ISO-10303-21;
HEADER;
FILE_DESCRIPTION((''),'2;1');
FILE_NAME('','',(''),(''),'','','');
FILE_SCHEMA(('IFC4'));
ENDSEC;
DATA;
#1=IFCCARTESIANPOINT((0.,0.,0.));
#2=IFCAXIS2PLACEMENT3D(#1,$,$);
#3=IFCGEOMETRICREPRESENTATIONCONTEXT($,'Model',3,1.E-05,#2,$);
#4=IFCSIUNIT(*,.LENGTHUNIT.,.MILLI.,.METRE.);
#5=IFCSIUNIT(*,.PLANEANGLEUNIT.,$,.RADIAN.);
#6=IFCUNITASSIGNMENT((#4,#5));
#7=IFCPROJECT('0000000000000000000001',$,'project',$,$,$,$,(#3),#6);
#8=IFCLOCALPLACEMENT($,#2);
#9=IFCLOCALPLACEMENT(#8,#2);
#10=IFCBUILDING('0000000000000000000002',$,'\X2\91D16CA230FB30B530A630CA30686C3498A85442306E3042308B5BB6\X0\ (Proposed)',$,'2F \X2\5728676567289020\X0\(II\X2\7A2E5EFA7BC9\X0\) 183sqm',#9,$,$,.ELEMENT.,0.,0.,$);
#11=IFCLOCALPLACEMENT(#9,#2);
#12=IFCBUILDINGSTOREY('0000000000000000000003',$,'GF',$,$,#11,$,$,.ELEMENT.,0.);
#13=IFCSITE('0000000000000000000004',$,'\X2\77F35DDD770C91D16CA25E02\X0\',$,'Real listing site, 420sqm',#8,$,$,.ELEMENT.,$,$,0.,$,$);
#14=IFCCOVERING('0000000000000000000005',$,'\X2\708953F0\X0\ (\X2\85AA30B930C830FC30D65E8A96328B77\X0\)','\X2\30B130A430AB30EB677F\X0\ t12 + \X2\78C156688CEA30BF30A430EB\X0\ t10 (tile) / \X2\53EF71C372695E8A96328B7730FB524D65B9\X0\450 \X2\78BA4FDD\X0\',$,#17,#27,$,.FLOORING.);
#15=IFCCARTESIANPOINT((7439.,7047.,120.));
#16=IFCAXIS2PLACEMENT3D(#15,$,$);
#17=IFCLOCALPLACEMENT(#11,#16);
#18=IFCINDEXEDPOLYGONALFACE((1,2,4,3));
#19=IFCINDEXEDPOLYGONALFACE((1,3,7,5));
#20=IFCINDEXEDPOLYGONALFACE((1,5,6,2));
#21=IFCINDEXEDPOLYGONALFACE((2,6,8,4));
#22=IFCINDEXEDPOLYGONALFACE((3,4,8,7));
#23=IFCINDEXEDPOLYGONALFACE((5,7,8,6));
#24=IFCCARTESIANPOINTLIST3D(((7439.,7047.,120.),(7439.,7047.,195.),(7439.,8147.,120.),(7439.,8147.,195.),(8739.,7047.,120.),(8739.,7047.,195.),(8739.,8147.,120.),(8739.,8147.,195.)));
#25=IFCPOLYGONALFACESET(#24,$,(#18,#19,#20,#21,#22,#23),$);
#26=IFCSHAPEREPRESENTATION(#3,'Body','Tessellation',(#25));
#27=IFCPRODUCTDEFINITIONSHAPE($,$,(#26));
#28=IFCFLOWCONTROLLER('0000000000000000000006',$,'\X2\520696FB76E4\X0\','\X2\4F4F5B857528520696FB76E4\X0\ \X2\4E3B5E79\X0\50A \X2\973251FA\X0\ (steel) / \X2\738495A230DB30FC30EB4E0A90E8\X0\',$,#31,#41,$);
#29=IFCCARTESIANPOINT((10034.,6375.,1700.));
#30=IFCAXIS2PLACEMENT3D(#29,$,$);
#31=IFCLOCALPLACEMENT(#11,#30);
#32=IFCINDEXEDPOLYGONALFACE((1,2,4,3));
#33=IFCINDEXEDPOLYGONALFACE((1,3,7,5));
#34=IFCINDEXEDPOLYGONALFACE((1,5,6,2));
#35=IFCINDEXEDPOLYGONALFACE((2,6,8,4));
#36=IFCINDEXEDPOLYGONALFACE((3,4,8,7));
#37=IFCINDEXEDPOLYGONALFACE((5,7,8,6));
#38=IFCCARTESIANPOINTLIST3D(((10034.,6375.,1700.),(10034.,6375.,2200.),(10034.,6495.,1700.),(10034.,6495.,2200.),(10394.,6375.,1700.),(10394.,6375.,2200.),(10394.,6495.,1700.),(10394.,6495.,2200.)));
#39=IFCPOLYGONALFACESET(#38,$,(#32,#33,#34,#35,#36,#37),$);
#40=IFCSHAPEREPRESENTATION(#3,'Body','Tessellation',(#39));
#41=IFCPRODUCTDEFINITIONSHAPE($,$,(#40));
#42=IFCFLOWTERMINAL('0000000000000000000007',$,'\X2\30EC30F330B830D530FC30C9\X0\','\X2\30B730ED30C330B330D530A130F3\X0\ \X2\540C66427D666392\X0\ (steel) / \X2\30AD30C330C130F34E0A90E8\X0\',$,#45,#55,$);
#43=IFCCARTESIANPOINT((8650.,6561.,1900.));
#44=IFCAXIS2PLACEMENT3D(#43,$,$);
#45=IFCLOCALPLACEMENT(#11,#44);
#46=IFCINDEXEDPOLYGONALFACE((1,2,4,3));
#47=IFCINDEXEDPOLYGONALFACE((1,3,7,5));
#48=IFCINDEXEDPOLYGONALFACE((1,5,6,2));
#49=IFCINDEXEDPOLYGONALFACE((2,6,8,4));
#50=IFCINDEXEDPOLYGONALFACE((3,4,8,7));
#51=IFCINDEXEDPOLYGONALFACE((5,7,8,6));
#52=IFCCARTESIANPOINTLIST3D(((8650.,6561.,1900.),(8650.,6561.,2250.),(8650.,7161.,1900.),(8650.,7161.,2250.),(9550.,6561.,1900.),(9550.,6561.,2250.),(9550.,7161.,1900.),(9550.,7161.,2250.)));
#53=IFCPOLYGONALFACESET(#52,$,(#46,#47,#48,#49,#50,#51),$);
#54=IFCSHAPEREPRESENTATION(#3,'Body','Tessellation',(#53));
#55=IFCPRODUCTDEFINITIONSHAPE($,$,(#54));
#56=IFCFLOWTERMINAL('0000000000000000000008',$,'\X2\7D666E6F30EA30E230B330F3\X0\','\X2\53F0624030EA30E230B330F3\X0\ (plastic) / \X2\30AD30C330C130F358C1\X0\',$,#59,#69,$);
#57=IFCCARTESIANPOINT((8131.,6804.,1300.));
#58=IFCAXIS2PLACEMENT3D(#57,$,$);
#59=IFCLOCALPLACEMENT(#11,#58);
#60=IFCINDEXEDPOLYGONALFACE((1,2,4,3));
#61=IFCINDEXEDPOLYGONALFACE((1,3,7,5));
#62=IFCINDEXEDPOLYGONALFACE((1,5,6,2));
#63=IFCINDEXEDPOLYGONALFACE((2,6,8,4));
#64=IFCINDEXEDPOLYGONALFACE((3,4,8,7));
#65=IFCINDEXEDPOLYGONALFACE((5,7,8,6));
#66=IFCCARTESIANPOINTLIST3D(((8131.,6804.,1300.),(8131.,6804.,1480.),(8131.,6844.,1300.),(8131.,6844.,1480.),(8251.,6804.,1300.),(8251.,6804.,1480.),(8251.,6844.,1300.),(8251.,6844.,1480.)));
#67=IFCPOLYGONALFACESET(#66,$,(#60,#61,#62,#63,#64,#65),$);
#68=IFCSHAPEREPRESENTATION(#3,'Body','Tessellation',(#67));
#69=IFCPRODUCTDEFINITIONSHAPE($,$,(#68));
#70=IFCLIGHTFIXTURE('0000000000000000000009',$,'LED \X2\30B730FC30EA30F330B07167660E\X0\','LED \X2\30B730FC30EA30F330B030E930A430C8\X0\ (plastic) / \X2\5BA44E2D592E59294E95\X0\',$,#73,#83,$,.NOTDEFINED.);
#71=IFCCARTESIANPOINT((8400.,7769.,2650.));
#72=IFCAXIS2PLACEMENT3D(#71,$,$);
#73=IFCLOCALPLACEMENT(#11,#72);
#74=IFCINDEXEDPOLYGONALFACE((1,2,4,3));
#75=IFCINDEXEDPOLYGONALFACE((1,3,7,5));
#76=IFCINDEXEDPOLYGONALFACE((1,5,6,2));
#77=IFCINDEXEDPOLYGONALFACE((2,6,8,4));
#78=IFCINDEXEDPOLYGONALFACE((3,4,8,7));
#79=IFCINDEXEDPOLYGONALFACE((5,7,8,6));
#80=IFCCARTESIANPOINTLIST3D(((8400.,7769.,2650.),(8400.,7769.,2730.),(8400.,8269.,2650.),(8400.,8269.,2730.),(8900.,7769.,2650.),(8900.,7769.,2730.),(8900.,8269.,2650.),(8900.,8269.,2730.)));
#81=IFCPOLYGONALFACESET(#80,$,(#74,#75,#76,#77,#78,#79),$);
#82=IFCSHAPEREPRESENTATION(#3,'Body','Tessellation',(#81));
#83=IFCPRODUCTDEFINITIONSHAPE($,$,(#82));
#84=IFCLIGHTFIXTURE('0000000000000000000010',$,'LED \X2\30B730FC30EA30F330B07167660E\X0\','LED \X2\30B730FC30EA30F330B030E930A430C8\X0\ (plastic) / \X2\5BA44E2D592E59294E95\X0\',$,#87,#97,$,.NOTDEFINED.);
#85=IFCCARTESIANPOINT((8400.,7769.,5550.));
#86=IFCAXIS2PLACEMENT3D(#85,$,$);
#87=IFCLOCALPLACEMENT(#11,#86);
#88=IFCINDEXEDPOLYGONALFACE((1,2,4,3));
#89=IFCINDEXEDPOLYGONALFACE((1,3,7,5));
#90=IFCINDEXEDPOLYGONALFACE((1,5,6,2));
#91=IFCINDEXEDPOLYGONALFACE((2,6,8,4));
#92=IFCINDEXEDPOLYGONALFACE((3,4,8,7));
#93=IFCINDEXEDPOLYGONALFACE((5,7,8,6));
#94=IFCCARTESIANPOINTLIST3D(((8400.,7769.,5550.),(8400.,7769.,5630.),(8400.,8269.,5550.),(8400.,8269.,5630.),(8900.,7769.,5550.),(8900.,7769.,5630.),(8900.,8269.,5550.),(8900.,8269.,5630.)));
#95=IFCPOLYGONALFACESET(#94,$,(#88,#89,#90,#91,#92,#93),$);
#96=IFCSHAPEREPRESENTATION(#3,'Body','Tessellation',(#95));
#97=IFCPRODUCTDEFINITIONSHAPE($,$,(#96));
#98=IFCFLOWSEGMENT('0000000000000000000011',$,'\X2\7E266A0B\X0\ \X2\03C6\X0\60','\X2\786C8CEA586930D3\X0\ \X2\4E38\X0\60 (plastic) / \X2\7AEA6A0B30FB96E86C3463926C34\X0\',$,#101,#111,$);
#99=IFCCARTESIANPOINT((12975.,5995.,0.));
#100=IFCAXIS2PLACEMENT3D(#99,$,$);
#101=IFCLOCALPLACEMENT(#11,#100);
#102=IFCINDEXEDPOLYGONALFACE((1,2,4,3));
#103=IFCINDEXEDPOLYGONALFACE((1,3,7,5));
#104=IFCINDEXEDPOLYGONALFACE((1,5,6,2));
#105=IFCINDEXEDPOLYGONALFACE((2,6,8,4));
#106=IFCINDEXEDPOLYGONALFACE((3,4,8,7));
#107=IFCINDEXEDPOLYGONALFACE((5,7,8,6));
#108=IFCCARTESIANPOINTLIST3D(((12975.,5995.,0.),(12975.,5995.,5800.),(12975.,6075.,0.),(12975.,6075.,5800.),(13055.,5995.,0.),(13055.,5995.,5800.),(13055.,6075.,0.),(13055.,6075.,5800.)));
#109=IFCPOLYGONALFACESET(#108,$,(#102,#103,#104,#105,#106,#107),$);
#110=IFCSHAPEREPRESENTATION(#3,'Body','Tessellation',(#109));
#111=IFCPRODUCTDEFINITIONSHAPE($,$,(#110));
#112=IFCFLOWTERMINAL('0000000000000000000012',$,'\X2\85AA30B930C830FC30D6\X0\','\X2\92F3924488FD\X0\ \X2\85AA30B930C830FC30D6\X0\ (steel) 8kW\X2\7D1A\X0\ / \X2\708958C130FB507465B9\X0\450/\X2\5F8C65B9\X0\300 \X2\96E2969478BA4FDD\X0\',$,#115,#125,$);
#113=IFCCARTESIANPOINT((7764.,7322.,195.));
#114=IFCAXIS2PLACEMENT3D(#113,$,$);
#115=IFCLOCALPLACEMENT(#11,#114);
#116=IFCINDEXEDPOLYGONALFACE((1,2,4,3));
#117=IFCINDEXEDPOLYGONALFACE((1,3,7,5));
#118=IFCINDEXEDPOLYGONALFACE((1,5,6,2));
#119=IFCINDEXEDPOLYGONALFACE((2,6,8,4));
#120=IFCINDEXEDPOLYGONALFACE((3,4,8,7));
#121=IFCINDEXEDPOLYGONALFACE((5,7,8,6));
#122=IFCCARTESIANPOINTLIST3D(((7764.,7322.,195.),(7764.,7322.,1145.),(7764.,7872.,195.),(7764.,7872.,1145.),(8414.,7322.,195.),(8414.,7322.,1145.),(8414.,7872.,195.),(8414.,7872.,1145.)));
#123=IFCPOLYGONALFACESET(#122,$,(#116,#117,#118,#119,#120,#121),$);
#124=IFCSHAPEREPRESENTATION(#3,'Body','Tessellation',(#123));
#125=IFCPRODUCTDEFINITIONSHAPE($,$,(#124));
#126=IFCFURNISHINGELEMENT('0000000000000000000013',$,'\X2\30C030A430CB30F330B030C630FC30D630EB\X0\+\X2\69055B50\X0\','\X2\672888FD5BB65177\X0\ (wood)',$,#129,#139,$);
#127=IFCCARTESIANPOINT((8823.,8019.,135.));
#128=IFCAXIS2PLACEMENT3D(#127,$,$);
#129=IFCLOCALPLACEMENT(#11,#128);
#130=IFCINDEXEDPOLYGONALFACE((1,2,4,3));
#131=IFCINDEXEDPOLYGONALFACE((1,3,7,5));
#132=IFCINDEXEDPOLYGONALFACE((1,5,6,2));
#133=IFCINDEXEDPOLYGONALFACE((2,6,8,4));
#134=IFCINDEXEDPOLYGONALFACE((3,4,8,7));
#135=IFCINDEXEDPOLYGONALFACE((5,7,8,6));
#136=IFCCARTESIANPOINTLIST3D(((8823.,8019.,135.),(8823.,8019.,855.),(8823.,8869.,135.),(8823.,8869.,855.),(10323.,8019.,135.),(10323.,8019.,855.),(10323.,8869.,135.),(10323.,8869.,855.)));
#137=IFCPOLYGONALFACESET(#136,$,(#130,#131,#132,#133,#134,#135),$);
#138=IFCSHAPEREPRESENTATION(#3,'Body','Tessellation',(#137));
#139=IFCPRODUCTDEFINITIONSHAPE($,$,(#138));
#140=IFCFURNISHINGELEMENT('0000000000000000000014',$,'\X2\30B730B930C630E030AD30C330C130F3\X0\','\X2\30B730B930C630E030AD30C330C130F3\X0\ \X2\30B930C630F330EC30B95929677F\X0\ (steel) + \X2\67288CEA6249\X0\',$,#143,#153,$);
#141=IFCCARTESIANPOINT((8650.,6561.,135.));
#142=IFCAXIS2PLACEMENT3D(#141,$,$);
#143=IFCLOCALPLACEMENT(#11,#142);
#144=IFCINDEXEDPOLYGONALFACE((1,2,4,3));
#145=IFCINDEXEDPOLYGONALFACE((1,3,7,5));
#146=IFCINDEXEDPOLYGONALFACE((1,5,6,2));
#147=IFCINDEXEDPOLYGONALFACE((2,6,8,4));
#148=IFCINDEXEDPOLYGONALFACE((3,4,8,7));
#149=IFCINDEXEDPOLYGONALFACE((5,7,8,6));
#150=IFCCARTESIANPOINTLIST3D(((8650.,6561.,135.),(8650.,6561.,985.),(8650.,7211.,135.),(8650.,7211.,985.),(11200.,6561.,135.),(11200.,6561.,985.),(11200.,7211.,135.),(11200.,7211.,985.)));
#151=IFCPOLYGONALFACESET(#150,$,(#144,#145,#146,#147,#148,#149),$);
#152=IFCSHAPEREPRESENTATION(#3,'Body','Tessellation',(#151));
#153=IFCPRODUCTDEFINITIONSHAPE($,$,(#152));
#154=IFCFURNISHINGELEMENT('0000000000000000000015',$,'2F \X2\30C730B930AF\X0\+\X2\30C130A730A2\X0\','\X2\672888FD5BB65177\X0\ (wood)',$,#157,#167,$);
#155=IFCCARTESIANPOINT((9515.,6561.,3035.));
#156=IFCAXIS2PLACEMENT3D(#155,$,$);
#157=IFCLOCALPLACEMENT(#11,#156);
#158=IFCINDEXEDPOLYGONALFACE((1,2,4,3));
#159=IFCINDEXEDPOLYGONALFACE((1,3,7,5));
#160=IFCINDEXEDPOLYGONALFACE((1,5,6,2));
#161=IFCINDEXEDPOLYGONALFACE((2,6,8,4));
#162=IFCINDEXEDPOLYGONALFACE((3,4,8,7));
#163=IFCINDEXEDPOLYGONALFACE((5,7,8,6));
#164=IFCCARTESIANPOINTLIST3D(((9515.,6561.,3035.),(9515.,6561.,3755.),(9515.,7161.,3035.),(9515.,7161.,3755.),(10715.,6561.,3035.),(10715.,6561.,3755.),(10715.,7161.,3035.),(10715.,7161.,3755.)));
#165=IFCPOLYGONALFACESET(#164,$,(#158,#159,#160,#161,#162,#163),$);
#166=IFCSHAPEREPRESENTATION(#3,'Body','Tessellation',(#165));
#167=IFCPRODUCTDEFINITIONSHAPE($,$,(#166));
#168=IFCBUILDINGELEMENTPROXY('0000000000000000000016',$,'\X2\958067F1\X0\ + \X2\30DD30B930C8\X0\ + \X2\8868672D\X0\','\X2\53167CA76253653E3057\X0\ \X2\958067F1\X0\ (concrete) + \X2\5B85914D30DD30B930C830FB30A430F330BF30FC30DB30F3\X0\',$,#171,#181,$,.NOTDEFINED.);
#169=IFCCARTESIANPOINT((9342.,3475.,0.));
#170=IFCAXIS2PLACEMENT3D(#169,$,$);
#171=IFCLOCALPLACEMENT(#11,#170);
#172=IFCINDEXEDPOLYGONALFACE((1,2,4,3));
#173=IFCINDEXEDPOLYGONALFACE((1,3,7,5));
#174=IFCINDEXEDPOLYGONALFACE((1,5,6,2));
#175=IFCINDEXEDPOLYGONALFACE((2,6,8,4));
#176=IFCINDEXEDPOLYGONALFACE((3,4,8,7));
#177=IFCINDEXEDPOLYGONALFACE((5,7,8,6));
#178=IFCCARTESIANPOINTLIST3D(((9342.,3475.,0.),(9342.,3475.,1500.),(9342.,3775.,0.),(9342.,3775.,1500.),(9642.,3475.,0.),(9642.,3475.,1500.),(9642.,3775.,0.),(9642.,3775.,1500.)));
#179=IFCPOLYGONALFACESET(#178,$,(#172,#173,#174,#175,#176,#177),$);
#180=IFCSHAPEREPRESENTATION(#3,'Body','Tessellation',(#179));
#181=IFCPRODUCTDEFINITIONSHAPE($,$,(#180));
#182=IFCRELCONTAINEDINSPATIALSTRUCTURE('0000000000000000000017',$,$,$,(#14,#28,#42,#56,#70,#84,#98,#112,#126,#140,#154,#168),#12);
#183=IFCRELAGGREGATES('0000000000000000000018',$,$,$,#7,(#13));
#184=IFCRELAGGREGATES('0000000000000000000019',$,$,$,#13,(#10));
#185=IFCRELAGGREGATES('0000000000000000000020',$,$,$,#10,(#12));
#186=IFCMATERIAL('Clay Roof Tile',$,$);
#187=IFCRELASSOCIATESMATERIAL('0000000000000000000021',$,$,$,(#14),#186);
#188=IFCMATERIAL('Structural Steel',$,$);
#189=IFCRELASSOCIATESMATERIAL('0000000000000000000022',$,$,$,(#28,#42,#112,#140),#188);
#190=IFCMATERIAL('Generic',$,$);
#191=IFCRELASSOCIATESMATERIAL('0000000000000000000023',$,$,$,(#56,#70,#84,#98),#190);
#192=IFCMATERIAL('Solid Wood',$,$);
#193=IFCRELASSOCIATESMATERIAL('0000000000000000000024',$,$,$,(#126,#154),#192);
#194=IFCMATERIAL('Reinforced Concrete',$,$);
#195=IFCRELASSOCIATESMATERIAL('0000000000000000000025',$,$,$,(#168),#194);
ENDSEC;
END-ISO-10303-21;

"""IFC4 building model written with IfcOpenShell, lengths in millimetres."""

from ifc_helpers import new_model, si_unit, frame, frame_2d, origin, place, context, project, spatial, rectangle, extrude, material, element, save


model = new_model("IFC4")

# Units and contexts
model_context = context("Model", 3, precision=1e-05, world=origin())
ifc_project = project(units=[si_unit("LENGTHUNIT", "METRE", prefix="MILLI"), si_unit("PLANEANGLEUNIT", "RADIAN")], contexts=[model_context])

# Site, building, storey
site_placement = place(None, origin())
site = spatial("IfcSite", under=ifc_project, at=site_placement, Name="石川県金沢市", ObjectType="Real listing site, 420sqm", CompositionType="ELEMENT", RefElevation=0.0)
building_placement = place(site_placement, origin())
building = spatial("IfcBuilding", under=site, at=building_placement, Name="金沢・サウナと水風呂のある家 (Proposed)", ObjectType="2F 在来木造(II種建築) 183sqm", CompositionType="ELEMENT", ElevationOfRefHeight=0.0, ElevationOfTerrain=0.0)
storey_placement = place(building_placement, origin())
storey = spatial("IfcBuildingStorey", under=building, at=storey_placement, Name="GF", CompositionType="ELEMENT", Elevation=0.0)

# Shared definitions
ifc_material_1 = material(Name="Solid Wood")

# Shared definitions
ifc_material_2 = material(Name="Structural Steel")

# Covering
ifc_material_3 = material(Name="Reinforced Concrete")
ifc_material_4 = material(Name="Clay Roof Tile")
covering_1_placement = place(storey_placement, frame((7439.0, 7047.0, 120.0)))
element("IfcCovering", 1, at=covering_1_placement, inside=storey, material=ifc_material_4, Name="炉台 (薪ストーブ床防護)", Description="ケイカル板 t12 + 磁器質タイル t10 (tile) / 可燃物床防護・前方450 確保", PredefinedType="FLOORING", context=model_context, shape_type="SweptSolid", body=[
    extrude(rectangle(XDim=1300.0, YDim=1100.0, at=frame_2d((650.0, 550.0))), frame((7439.0, 7047.0, 120.0)), (0.0, 0.0, 1.0), 75.0),
])

# Flow controller
flow_controller_placement = place(storey_placement, frame((10034.0, 6375.0, 1700.0)))
element("IfcFlowController", 2, at=flow_controller_placement, inside=storey, material=ifc_material_2, Name="分電盤", Description="住宅用分電盤 主幹50A 露出 (steel) / 玄関ホール上部", context=model_context, shape_type="SweptSolid", body=[
    extrude(rectangle(XDim=360.0, YDim=120.0, at=frame_2d((180.0, 60.0))), frame((10034.0, 6375.0, 1700.0)), (0.0, 0.0, 1.0), 500.0),
])

# Flow terminals
flow_terminal_1_placement = place(storey_placement, frame((8650.0, 6561.0, 1900.0)))
element("IfcFlowTerminal", 3, at=flow_terminal_1_placement, inside=storey, material=ifc_material_2, Name="レンジフード", Description="シロッコファン 同時給排 (steel) / キッチン上部", context=model_context, shape_type="SweptSolid", body=[
    extrude(rectangle(XDim=900.0, YDim=600.0, at=frame_2d((450.0, 300.0))), frame((8650.0, 6561.0, 1900.0)), (0.0, 0.0, 1.0), 350.0),
])
ifc_material_5 = material(Name="Generic")
flow_terminal_2_placement = place(storey_placement, frame((8131.0, 6804.0, 1300.0)))
element("IfcFlowTerminal", 4, at=flow_terminal_2_placement, inside=storey, material=ifc_material_5, Name="給湯リモコン", Description="台所リモコン (plastic) / キッチン壁", context=model_context, shape_type="SweptSolid", body=[
    extrude(rectangle(XDim=120.0, YDim=40.0, at=frame_2d((60.0, 20.0))), frame((8131.0, 6804.0, 1300.0)), (0.0, 0.0, 1.0), 180.0),
])

# Light fixtures
light_fixture_1_placement = place(storey_placement, frame((8400.0, 7769.0, 2650.0)))
element("IfcLightFixture", 5, at=light_fixture_1_placement, inside=storey, material=ifc_material_5, Name="LED シーリング照明", Description="LED シーリングライト (plastic) / 室中央天井", PredefinedType="NOTDEFINED", context=model_context, shape_type="SweptSolid", body=[
    extrude(rectangle(XDim=500.0, YDim=500.0, at=frame_2d((250.0, 250.0))), frame((8400.0, 7769.0, 2650.0)), (0.0, 0.0, 1.0), 80.0),
])
light_fixture_2_placement = place(storey_placement, frame((8400.0, 7769.0, 5550.0)))
element("IfcLightFixture", 6, at=light_fixture_2_placement, inside=storey, material=ifc_material_5, Name="LED シーリング照明", Description="LED シーリングライト (plastic) / 室中央天井", PredefinedType="NOTDEFINED", context=model_context, shape_type="SweptSolid", body=[
    extrude(rectangle(XDim=500.0, YDim=500.0, at=frame_2d((250.0, 250.0))), frame((8400.0, 7769.0, 5550.0)), (0.0, 0.0, 1.0), 80.0),
])

# Flow segment
flow_segment_placement = place(storey_placement, frame((12975.0, 5995.0, 0.0)))
element("IfcFlowSegment", 7, at=flow_segment_placement, inside=storey, material=ifc_material_5, Name="縦樋 φ60", Description="硬質塩ビ 丸60 (plastic) / 竪樋・雨水排水", context=model_context, shape_type="SweptSolid", body=[
    extrude(rectangle(XDim=80.0, YDim=80.0, at=frame_2d((40.0, 40.0))), frame((12975.0, 5995.0, 0.0)), (0.0, 0.0, 1.0), 5800.0),
])

# Flow terminal
flow_terminal_3_placement = place(storey_placement, frame((7764.0, 7322.0, 195.0)))
element("IfcFlowTerminal", 8, at=flow_terminal_3_placement, inside=storey, material=ifc_material_2, Name="薪ストーブ", Description="鋳鉄製 薪ストーブ (steel) 8kW級 / 炉壁・側方450/後方300 離隔確保", context=model_context, shape_type="SweptSolid", body=[
    extrude(rectangle(XDim=650.0, YDim=550.0, at=frame_2d((325.0, 275.0))), frame((7764.0, 7322.0, 195.0)), (0.0, 0.0, 1.0), 950.0),
])

# Furnishing elements
furnishing_1_placement = place(storey_placement, frame((8823.0, 8019.0, 135.0)))
element("IfcFurnishingElement", 9, at=furnishing_1_placement, inside=storey, material=ifc_material_1, Name="ダイニングテーブル+椅子", Description="木製家具 (wood)", context=model_context, shape_type="SweptSolid", body=[
    extrude(rectangle(XDim=1500.0, YDim=850.0, at=frame_2d((750.0, 425.0))), frame((8823.0, 8019.0, 135.0)), (0.0, 0.0, 1.0), 720.0),
])
furnishing_2_placement = place(storey_placement, frame((8650.0, 6561.0, 135.0)))
element("IfcFurnishingElement", 10, at=furnishing_2_placement, inside=storey, material=ifc_material_2, Name="システムキッチン", Description="システムキッチン ステンレス天板 (steel) + 木質扉", context=model_context, shape_type="SweptSolid", body=[
    extrude(rectangle(XDim=2550.0, YDim=650.0, at=frame_2d((1275.0, 325.0))), frame((8650.0, 6561.0, 135.0)), (0.0, 0.0, 1.0), 850.0),
])
furnishing_3_placement = place(storey_placement, frame((9515.0, 6561.0, 3035.0)))
element("IfcFurnishingElement", 11, at=furnishing_3_placement, inside=storey, material=ifc_material_1, Name="2F デスク+チェア", Description="木製家具 (wood)", context=model_context, shape_type="SweptSolid", body=[
    extrude(rectangle(XDim=1200.0, YDim=600.0, at=frame_2d((600.0, 300.0))), frame((9515.0, 6561.0, 3035.0)), (0.0, 0.0, 1.0), 720.0),
])

# Building element proxy
proxy_placement = place(storey_placement, frame((9342.0, 3475.0, 0.0)))
element("IfcBuildingElementProxy", 12, at=proxy_placement, inside=storey, material=ifc_material_3, Name="門柱 + ポスト + 表札", Description="化粧打放し 門柱 (concrete) + 宅配ポスト・インターホン", PredefinedType="NOTDEFINED", context=model_context, shape_type="SweptSolid", body=[
    extrude(rectangle(XDim=300.0, YDim=300.0, at=frame_2d((150.0, 150.0))), frame((9342.0, 3475.0, 0.0)), (0.0, 0.0, 1.0), 1500.0),
])

save(model, "model.ifc")
